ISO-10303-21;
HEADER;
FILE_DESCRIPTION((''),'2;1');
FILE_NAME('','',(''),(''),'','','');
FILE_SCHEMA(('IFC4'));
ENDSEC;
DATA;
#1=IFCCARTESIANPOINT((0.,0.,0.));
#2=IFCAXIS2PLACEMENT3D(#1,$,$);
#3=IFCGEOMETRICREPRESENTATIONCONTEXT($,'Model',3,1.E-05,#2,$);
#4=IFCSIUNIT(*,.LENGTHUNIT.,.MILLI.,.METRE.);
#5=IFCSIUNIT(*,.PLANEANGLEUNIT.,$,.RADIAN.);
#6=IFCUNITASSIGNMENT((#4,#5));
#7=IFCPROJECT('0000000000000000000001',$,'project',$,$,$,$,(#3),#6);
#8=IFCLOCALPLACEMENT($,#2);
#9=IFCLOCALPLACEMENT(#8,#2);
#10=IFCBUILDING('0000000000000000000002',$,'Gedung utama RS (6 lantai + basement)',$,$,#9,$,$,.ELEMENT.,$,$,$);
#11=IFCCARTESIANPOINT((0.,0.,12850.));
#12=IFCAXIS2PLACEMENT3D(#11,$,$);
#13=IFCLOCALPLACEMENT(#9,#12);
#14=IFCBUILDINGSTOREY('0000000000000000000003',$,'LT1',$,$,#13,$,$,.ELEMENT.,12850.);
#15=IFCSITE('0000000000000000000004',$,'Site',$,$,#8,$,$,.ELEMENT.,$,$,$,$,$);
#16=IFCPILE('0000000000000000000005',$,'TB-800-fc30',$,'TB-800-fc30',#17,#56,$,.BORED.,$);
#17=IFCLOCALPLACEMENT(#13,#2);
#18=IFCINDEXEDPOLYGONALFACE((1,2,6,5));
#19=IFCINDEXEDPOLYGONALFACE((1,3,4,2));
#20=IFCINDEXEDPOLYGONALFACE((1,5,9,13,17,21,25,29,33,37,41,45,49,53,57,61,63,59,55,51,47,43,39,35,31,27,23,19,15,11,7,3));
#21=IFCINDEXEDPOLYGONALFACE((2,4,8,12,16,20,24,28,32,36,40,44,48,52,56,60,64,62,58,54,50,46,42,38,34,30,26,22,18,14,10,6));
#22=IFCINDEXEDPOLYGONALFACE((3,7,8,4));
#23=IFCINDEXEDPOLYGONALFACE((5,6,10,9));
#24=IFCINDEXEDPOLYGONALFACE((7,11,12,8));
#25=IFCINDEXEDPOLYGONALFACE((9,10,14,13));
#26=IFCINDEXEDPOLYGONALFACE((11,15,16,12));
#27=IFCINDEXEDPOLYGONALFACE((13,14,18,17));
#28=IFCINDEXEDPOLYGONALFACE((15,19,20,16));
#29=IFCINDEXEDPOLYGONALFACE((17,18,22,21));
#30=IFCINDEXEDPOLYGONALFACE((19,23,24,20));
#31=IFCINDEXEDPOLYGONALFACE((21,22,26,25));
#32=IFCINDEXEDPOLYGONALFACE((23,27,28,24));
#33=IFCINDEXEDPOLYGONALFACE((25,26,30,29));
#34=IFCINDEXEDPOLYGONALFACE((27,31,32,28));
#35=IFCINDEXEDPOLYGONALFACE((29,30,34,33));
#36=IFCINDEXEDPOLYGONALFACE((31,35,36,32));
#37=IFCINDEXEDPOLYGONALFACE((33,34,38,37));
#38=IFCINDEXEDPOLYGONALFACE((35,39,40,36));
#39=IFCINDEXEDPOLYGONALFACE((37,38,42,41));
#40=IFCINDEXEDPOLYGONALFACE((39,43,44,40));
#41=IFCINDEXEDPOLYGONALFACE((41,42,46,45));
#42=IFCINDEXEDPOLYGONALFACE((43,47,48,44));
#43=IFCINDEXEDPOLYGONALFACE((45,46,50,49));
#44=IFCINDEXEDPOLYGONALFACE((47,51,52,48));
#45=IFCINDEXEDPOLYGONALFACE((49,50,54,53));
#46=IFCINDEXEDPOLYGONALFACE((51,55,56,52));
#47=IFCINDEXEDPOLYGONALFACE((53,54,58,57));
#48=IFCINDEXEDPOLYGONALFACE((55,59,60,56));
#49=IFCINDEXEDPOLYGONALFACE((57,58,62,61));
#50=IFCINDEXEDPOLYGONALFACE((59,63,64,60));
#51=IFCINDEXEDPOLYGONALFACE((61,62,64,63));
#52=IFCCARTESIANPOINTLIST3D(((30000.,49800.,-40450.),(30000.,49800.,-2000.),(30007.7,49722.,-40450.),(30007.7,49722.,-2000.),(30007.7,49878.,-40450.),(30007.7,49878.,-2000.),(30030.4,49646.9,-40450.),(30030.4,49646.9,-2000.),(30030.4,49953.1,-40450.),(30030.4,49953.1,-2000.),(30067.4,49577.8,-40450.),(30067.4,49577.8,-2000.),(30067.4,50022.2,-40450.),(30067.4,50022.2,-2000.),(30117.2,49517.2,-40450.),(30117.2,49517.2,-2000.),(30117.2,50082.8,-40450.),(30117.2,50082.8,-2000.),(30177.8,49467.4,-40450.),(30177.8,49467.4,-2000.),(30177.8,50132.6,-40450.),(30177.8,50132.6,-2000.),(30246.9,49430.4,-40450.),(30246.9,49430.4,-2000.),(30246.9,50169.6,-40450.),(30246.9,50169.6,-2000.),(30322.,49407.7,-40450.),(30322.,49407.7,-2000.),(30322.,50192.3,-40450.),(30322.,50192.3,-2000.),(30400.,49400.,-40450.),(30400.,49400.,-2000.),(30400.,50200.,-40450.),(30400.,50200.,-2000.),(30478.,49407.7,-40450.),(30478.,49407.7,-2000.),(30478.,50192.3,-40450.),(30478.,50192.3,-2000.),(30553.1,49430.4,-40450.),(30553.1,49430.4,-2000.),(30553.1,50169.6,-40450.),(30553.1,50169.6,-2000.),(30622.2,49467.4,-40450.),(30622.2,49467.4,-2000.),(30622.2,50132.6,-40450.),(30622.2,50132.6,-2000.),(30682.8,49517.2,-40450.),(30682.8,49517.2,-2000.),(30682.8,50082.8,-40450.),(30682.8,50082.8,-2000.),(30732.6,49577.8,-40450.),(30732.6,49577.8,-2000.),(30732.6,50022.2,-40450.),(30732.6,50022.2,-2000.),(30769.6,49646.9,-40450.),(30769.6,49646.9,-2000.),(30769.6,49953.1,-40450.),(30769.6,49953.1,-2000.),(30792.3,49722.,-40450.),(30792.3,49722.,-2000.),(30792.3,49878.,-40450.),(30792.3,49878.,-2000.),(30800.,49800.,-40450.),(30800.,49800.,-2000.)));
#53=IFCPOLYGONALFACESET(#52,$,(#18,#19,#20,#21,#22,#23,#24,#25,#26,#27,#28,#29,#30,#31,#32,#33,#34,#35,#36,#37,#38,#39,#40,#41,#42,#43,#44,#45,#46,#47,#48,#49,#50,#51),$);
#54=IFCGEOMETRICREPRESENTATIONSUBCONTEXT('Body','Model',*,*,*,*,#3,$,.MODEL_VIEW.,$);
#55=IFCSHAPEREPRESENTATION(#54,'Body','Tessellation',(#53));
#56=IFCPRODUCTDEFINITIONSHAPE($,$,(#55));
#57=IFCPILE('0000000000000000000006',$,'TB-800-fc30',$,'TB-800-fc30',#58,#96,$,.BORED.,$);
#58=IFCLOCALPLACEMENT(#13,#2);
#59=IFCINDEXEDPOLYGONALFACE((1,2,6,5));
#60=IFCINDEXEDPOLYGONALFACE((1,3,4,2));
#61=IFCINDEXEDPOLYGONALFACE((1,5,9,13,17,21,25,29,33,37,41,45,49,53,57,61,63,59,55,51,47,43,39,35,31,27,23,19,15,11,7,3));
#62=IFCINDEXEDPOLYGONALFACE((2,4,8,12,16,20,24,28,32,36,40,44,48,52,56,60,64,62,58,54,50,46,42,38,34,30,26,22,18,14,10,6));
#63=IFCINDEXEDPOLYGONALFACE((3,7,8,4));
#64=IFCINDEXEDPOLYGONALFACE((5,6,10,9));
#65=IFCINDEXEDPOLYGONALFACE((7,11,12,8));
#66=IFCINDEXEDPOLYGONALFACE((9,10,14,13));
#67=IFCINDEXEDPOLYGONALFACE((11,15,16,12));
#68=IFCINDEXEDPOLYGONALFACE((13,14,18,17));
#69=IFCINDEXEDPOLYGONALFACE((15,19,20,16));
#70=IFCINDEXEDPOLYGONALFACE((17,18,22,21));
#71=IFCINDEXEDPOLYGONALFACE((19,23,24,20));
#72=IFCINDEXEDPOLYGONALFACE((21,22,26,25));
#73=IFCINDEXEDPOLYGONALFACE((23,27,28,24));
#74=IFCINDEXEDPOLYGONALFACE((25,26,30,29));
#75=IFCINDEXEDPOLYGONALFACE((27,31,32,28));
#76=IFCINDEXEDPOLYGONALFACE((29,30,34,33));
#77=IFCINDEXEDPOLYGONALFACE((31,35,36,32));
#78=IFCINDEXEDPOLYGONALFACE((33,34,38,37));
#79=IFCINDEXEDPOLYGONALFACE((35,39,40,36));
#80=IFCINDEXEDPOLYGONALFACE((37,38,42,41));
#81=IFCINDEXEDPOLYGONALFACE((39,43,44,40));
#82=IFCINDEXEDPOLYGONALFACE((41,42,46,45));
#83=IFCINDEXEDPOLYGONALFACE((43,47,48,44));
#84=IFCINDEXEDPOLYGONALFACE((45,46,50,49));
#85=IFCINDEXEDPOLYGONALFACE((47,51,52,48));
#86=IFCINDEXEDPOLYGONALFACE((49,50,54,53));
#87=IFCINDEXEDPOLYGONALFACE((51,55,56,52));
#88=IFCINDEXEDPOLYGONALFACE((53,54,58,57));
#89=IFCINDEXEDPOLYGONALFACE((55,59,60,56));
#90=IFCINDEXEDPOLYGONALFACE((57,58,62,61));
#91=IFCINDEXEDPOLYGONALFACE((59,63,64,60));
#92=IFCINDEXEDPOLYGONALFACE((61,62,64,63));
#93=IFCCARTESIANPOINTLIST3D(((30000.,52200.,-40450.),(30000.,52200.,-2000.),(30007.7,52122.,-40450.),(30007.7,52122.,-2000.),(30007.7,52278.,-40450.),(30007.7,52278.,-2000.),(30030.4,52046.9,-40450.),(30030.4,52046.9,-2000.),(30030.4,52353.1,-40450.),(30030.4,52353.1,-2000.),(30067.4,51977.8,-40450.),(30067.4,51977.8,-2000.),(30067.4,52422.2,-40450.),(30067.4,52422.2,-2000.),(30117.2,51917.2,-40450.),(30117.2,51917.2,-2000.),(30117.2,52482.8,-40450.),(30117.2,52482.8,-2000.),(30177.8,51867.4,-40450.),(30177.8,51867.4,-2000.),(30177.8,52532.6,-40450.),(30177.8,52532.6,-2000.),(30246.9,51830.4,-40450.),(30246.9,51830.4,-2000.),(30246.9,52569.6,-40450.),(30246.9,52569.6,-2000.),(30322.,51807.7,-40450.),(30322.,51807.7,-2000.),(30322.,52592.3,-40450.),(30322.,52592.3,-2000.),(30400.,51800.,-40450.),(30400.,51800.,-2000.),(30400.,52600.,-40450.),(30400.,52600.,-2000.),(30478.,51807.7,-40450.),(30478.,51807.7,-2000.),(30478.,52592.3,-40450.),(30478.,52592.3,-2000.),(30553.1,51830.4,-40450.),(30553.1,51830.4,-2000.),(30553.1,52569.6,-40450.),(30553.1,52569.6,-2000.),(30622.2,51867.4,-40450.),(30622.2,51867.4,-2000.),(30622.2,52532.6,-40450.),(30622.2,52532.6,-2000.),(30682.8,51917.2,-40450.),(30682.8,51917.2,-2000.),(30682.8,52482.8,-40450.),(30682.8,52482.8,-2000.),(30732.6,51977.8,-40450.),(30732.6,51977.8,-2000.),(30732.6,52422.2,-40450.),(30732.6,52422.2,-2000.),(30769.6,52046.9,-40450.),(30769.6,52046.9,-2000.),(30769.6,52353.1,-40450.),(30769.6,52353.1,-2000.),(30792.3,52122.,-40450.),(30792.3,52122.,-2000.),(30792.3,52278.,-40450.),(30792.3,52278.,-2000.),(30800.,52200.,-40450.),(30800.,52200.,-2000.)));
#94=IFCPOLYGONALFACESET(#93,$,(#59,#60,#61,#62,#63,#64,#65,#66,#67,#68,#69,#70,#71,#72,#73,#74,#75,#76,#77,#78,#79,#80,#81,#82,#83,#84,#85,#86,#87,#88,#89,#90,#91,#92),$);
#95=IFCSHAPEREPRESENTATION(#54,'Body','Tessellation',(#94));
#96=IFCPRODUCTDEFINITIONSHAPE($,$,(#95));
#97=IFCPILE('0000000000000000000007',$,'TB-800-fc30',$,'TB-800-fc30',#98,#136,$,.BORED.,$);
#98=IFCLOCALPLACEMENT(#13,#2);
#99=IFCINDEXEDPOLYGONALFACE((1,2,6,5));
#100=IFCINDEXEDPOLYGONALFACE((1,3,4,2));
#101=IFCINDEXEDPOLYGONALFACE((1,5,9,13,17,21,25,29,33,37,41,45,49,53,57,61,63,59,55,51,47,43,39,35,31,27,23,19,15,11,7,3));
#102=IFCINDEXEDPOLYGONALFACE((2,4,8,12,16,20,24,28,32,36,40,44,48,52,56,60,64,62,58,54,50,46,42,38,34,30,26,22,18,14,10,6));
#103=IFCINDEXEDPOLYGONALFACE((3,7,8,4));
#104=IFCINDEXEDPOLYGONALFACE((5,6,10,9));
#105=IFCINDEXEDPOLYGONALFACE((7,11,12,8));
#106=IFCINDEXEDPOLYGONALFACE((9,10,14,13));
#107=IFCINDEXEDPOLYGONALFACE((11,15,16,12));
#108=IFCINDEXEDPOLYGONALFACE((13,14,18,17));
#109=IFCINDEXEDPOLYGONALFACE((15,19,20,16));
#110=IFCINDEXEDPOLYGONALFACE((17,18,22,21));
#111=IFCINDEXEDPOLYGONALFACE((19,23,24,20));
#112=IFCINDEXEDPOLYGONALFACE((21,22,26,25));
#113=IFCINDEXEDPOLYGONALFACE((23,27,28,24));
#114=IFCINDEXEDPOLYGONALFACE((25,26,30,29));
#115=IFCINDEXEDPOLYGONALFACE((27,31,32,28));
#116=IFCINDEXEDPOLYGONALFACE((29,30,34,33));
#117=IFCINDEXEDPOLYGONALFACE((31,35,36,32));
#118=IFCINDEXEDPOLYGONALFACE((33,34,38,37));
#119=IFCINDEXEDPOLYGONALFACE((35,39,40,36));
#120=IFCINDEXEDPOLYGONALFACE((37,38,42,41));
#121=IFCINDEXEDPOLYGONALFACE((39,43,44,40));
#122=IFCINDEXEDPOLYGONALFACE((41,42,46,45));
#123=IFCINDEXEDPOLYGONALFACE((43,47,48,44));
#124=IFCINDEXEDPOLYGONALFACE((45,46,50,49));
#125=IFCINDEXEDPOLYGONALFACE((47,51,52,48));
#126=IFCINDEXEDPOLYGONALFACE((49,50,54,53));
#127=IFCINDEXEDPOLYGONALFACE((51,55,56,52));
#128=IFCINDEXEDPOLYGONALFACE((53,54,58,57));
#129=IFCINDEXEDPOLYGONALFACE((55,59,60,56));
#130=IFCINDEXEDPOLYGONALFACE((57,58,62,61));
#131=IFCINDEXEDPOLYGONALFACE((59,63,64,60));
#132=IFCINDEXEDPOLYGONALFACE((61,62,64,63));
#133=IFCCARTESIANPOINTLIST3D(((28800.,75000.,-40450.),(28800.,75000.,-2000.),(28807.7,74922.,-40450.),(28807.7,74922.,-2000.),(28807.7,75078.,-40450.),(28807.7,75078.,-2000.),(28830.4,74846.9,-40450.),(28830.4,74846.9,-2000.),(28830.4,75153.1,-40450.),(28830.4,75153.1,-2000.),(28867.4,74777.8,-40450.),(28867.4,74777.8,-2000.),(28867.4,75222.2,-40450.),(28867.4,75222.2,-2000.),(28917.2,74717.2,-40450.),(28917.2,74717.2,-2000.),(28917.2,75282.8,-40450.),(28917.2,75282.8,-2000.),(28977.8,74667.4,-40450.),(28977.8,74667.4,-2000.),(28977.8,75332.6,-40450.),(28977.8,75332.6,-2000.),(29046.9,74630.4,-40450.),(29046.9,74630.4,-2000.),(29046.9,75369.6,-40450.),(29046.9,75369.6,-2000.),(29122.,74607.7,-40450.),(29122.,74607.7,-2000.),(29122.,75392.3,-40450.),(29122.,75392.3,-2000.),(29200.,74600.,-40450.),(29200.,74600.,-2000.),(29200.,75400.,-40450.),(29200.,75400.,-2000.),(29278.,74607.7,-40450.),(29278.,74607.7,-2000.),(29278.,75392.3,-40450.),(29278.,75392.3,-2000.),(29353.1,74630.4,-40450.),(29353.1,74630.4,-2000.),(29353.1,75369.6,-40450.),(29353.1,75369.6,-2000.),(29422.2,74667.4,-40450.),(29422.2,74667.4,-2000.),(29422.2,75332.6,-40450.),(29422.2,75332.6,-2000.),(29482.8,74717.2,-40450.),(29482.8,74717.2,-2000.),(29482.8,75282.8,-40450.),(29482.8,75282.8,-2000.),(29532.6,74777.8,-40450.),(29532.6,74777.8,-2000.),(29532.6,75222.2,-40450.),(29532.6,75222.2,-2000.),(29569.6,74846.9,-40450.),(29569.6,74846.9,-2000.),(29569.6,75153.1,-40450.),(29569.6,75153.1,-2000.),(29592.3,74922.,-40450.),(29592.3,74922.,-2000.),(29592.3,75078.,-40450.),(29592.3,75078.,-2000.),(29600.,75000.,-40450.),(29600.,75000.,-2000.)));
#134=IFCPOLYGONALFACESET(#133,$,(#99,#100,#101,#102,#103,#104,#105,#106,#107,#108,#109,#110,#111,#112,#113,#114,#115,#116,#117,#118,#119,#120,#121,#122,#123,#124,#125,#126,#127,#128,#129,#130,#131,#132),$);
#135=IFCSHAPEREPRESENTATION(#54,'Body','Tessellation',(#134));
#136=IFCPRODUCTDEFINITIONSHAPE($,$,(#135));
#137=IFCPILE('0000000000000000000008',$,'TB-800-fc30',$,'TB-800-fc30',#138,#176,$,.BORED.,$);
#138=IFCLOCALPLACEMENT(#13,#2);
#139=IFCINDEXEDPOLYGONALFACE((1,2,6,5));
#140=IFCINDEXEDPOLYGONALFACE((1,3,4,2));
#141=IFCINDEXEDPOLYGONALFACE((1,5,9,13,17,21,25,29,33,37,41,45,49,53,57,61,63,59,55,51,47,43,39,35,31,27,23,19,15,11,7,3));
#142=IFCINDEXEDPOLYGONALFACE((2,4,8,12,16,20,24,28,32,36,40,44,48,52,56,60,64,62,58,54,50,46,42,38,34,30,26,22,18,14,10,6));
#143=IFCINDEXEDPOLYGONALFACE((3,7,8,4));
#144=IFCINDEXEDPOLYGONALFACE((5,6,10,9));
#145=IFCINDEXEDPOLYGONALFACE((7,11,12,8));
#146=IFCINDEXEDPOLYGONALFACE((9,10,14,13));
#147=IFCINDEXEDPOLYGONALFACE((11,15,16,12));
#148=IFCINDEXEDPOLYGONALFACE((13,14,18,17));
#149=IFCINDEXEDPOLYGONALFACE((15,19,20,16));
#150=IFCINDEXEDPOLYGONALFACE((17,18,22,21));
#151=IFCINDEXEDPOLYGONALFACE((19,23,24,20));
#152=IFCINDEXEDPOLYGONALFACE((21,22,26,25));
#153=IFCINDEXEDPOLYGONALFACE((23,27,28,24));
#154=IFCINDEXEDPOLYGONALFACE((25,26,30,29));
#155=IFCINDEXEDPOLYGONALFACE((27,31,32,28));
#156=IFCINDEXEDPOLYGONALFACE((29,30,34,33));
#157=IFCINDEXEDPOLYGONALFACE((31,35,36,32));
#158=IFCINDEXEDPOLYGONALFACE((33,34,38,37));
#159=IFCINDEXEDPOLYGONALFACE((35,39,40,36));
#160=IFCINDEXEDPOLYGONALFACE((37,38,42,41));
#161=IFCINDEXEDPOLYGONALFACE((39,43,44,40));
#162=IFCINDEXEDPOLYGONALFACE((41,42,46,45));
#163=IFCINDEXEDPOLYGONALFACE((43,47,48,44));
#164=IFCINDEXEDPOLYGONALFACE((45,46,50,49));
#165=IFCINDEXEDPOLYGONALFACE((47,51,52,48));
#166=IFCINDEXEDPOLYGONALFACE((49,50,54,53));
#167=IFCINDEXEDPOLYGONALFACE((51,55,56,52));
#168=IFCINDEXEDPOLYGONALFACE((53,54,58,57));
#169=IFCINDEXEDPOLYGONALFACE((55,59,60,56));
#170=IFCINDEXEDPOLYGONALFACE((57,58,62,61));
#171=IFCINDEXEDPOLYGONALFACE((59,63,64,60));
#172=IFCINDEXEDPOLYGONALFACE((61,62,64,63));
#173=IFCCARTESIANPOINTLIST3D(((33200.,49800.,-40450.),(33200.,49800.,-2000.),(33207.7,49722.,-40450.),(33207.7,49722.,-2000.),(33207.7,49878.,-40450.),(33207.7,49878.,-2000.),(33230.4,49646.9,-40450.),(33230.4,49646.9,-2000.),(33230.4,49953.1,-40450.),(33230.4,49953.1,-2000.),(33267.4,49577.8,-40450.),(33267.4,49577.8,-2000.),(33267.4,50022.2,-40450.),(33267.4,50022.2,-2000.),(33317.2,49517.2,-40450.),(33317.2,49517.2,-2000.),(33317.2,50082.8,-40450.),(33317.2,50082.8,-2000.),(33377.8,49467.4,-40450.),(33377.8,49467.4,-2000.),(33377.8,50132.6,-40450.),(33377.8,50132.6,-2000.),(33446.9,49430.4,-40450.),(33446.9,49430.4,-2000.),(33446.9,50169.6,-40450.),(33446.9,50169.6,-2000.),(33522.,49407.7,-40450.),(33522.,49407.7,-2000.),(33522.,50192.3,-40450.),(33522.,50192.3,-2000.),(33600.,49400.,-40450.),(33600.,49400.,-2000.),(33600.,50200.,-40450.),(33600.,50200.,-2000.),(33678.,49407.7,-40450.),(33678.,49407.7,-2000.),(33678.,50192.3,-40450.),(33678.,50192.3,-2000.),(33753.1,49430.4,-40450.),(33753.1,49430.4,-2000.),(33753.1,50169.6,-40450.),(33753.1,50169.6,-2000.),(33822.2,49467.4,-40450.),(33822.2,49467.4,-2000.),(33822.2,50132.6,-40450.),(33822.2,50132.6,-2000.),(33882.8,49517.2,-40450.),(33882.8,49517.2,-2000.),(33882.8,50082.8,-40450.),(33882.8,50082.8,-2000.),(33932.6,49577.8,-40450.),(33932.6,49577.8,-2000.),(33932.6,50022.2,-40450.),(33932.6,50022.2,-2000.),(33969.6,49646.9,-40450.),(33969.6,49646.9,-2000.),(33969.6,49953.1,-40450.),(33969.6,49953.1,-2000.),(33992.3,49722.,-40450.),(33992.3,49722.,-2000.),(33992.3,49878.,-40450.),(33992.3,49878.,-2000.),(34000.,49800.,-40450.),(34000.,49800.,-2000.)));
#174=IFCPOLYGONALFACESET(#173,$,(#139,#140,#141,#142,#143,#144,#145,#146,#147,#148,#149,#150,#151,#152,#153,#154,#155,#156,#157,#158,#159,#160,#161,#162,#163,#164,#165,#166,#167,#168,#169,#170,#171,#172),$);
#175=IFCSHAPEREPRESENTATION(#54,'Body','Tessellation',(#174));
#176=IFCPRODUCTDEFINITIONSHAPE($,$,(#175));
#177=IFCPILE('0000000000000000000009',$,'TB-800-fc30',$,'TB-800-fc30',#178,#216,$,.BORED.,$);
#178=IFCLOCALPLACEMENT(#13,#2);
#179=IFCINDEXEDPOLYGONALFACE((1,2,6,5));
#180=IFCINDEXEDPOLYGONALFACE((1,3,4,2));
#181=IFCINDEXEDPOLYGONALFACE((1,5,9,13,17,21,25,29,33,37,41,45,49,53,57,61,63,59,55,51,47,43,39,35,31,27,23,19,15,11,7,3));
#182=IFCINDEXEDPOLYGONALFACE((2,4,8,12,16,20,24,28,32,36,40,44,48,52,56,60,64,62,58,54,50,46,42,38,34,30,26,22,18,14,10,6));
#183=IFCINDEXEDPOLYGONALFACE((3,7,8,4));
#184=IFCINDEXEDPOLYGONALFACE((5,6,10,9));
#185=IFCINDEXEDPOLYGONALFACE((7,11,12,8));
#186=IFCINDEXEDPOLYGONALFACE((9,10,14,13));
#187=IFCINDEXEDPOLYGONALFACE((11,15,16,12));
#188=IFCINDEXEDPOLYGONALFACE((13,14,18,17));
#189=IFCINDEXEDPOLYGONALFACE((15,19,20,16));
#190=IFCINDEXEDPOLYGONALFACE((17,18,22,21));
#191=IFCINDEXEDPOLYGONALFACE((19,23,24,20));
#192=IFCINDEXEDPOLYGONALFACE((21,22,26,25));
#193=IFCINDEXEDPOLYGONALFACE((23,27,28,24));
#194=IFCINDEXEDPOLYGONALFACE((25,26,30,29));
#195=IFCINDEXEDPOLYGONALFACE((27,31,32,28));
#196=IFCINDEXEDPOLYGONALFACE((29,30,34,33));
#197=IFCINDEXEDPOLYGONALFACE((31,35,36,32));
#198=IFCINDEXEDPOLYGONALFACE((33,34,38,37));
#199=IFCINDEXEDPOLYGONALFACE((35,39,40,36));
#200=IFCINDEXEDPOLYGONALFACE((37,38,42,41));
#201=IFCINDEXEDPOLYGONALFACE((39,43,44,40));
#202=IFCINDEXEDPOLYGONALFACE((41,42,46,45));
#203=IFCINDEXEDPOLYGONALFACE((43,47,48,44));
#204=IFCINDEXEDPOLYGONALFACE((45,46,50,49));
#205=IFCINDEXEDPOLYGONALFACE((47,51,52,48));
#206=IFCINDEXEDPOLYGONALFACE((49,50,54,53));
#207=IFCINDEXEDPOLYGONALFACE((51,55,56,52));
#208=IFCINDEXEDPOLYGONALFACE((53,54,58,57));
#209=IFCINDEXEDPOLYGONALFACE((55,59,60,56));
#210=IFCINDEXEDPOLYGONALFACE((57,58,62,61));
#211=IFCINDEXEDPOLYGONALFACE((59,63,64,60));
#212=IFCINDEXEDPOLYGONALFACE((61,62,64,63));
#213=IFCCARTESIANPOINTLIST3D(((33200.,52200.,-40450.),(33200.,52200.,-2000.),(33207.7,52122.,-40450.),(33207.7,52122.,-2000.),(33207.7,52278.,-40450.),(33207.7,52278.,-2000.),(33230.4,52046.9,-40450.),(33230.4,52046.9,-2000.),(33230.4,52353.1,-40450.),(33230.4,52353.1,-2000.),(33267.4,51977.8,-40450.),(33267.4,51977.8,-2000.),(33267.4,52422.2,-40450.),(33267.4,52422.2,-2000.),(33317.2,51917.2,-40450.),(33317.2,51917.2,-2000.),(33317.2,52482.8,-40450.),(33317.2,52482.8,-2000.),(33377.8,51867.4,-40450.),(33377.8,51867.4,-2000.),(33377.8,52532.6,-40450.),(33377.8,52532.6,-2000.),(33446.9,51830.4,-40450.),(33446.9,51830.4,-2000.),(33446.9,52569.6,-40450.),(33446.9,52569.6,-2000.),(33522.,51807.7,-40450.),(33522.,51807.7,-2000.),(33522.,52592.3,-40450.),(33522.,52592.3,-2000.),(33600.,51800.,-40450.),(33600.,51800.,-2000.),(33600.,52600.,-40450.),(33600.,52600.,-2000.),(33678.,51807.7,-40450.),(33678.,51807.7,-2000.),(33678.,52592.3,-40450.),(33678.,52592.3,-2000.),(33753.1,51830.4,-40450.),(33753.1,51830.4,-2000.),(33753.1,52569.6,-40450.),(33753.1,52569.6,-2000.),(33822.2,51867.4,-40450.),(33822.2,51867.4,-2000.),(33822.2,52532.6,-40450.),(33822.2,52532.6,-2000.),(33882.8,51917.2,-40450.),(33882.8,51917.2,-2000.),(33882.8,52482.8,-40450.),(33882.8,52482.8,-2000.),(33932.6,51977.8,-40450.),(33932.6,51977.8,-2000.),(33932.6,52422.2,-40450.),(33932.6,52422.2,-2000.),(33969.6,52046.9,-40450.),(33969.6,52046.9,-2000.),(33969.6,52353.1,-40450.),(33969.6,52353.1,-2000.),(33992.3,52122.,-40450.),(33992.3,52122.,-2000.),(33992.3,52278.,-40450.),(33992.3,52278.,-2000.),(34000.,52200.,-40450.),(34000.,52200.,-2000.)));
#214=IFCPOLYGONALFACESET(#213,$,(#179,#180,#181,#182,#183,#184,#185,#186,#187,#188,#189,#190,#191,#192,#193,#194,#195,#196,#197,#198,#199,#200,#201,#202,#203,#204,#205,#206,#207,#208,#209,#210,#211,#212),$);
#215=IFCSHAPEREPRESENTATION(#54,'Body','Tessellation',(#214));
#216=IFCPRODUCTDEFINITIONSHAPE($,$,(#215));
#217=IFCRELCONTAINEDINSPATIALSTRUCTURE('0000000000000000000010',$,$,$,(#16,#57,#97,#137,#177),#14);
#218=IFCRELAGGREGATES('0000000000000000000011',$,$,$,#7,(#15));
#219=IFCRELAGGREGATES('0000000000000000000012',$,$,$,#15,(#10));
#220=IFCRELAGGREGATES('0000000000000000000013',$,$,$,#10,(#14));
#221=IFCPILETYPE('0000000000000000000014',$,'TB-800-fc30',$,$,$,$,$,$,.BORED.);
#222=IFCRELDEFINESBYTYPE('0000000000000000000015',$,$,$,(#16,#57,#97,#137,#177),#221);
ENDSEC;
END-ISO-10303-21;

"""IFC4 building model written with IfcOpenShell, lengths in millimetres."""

from ifc_helpers import new_model, si_unit, frame, origin, origin_2d, place, context, subcontext, project, spatial, circle, extrude, material_profile, profile_set, profile_usage, type_object, element, save


model = new_model("IFC4")

# Units and contexts
model_context = context("Model", 3, precision=1e-05, world=origin())
body_context = subcontext(model_context, "Body", "Model", "MODEL_VIEW")
ifc_project = project(units=[si_unit("LENGTHUNIT", "METRE", prefix="MILLI"), si_unit("PLANEANGLEUNIT", "RADIAN")], contexts=[model_context])

# Site, building, storey
site_placement = place(None, origin())
site = spatial("IfcSite", under=ifc_project, at=site_placement, Name="Site", CompositionType="ELEMENT")
building_placement = place(site_placement, origin())
building = spatial("IfcBuilding", under=site, at=building_placement, Name="Gedung utama RS (6 lantai + basement)", CompositionType="ELEMENT")
storey_placement = place(building_placement, frame((0.0, 0.0, 12850.0)))
storey = spatial("IfcBuildingStorey", under=building, at=storey_placement, Name="LT1", CompositionType="ELEMENT", Elevation=12850.0)

# Piles
ifc_material_profile_1 = material_profile(None, circle(Radius=400.0, at=origin_2d()), Name="TB-800-fc30")
ifc_profile_set_1 = profile_set([ifc_material_profile_1], Name="TB-800-fc30")
ifc_profile_usage_1 = profile_usage(ifc_profile_set_1, cardinal=5)
pile_type = type_object("IfcPileType", Name="TB-800-fc30", PredefinedType="BORED", material=ifc_profile_set_1)
for number, where, z_axis, x_axis, name in (
    (1, (30400.0, 49800.0, -40450.0), (0.0, 0.0, 1.0), (1.0, 0.0, 0.0), "TB-800-fc30"),
    (2, (30400.0, 52200.0, -40450.0), (0.0, 0.0, 1.0), (1.0, 0.0, 0.0), "TB-800-fc30"),
    (3, (29200.0, 75000.0, -40450.0), (0.0, 0.0, 1.0), (1.0, 0.0, 0.0), "TB-800-fc30"),
    (4, (33600.0, 49800.0, -40450.0), (0.0, 0.0, 1.0), (1.0, 0.0, 0.0), "TB-800-fc30"),
    (5, (33600.0, 52200.0, -40450.0), (0.0, 0.0, 1.0), (1.0, 0.0, 0.0), "TB-800-fc30"),
):
    element("IfcPile", number, at=place(storey_placement, frame(where, z_axis=z_axis, x_axis=x_axis)), inside=storey, type_object=pile_type, material=ifc_profile_usage_1, Name=name, ObjectType="TB-800-fc30", PredefinedType="BORED", context=body_context, shape_type="SweptSolid", body=[
        extrude(circle(Radius=400.0, at=origin_2d()), origin(), (0.0, 0.0, 1.0), 38450.0),
    ])

save(model, "model.ifc")
